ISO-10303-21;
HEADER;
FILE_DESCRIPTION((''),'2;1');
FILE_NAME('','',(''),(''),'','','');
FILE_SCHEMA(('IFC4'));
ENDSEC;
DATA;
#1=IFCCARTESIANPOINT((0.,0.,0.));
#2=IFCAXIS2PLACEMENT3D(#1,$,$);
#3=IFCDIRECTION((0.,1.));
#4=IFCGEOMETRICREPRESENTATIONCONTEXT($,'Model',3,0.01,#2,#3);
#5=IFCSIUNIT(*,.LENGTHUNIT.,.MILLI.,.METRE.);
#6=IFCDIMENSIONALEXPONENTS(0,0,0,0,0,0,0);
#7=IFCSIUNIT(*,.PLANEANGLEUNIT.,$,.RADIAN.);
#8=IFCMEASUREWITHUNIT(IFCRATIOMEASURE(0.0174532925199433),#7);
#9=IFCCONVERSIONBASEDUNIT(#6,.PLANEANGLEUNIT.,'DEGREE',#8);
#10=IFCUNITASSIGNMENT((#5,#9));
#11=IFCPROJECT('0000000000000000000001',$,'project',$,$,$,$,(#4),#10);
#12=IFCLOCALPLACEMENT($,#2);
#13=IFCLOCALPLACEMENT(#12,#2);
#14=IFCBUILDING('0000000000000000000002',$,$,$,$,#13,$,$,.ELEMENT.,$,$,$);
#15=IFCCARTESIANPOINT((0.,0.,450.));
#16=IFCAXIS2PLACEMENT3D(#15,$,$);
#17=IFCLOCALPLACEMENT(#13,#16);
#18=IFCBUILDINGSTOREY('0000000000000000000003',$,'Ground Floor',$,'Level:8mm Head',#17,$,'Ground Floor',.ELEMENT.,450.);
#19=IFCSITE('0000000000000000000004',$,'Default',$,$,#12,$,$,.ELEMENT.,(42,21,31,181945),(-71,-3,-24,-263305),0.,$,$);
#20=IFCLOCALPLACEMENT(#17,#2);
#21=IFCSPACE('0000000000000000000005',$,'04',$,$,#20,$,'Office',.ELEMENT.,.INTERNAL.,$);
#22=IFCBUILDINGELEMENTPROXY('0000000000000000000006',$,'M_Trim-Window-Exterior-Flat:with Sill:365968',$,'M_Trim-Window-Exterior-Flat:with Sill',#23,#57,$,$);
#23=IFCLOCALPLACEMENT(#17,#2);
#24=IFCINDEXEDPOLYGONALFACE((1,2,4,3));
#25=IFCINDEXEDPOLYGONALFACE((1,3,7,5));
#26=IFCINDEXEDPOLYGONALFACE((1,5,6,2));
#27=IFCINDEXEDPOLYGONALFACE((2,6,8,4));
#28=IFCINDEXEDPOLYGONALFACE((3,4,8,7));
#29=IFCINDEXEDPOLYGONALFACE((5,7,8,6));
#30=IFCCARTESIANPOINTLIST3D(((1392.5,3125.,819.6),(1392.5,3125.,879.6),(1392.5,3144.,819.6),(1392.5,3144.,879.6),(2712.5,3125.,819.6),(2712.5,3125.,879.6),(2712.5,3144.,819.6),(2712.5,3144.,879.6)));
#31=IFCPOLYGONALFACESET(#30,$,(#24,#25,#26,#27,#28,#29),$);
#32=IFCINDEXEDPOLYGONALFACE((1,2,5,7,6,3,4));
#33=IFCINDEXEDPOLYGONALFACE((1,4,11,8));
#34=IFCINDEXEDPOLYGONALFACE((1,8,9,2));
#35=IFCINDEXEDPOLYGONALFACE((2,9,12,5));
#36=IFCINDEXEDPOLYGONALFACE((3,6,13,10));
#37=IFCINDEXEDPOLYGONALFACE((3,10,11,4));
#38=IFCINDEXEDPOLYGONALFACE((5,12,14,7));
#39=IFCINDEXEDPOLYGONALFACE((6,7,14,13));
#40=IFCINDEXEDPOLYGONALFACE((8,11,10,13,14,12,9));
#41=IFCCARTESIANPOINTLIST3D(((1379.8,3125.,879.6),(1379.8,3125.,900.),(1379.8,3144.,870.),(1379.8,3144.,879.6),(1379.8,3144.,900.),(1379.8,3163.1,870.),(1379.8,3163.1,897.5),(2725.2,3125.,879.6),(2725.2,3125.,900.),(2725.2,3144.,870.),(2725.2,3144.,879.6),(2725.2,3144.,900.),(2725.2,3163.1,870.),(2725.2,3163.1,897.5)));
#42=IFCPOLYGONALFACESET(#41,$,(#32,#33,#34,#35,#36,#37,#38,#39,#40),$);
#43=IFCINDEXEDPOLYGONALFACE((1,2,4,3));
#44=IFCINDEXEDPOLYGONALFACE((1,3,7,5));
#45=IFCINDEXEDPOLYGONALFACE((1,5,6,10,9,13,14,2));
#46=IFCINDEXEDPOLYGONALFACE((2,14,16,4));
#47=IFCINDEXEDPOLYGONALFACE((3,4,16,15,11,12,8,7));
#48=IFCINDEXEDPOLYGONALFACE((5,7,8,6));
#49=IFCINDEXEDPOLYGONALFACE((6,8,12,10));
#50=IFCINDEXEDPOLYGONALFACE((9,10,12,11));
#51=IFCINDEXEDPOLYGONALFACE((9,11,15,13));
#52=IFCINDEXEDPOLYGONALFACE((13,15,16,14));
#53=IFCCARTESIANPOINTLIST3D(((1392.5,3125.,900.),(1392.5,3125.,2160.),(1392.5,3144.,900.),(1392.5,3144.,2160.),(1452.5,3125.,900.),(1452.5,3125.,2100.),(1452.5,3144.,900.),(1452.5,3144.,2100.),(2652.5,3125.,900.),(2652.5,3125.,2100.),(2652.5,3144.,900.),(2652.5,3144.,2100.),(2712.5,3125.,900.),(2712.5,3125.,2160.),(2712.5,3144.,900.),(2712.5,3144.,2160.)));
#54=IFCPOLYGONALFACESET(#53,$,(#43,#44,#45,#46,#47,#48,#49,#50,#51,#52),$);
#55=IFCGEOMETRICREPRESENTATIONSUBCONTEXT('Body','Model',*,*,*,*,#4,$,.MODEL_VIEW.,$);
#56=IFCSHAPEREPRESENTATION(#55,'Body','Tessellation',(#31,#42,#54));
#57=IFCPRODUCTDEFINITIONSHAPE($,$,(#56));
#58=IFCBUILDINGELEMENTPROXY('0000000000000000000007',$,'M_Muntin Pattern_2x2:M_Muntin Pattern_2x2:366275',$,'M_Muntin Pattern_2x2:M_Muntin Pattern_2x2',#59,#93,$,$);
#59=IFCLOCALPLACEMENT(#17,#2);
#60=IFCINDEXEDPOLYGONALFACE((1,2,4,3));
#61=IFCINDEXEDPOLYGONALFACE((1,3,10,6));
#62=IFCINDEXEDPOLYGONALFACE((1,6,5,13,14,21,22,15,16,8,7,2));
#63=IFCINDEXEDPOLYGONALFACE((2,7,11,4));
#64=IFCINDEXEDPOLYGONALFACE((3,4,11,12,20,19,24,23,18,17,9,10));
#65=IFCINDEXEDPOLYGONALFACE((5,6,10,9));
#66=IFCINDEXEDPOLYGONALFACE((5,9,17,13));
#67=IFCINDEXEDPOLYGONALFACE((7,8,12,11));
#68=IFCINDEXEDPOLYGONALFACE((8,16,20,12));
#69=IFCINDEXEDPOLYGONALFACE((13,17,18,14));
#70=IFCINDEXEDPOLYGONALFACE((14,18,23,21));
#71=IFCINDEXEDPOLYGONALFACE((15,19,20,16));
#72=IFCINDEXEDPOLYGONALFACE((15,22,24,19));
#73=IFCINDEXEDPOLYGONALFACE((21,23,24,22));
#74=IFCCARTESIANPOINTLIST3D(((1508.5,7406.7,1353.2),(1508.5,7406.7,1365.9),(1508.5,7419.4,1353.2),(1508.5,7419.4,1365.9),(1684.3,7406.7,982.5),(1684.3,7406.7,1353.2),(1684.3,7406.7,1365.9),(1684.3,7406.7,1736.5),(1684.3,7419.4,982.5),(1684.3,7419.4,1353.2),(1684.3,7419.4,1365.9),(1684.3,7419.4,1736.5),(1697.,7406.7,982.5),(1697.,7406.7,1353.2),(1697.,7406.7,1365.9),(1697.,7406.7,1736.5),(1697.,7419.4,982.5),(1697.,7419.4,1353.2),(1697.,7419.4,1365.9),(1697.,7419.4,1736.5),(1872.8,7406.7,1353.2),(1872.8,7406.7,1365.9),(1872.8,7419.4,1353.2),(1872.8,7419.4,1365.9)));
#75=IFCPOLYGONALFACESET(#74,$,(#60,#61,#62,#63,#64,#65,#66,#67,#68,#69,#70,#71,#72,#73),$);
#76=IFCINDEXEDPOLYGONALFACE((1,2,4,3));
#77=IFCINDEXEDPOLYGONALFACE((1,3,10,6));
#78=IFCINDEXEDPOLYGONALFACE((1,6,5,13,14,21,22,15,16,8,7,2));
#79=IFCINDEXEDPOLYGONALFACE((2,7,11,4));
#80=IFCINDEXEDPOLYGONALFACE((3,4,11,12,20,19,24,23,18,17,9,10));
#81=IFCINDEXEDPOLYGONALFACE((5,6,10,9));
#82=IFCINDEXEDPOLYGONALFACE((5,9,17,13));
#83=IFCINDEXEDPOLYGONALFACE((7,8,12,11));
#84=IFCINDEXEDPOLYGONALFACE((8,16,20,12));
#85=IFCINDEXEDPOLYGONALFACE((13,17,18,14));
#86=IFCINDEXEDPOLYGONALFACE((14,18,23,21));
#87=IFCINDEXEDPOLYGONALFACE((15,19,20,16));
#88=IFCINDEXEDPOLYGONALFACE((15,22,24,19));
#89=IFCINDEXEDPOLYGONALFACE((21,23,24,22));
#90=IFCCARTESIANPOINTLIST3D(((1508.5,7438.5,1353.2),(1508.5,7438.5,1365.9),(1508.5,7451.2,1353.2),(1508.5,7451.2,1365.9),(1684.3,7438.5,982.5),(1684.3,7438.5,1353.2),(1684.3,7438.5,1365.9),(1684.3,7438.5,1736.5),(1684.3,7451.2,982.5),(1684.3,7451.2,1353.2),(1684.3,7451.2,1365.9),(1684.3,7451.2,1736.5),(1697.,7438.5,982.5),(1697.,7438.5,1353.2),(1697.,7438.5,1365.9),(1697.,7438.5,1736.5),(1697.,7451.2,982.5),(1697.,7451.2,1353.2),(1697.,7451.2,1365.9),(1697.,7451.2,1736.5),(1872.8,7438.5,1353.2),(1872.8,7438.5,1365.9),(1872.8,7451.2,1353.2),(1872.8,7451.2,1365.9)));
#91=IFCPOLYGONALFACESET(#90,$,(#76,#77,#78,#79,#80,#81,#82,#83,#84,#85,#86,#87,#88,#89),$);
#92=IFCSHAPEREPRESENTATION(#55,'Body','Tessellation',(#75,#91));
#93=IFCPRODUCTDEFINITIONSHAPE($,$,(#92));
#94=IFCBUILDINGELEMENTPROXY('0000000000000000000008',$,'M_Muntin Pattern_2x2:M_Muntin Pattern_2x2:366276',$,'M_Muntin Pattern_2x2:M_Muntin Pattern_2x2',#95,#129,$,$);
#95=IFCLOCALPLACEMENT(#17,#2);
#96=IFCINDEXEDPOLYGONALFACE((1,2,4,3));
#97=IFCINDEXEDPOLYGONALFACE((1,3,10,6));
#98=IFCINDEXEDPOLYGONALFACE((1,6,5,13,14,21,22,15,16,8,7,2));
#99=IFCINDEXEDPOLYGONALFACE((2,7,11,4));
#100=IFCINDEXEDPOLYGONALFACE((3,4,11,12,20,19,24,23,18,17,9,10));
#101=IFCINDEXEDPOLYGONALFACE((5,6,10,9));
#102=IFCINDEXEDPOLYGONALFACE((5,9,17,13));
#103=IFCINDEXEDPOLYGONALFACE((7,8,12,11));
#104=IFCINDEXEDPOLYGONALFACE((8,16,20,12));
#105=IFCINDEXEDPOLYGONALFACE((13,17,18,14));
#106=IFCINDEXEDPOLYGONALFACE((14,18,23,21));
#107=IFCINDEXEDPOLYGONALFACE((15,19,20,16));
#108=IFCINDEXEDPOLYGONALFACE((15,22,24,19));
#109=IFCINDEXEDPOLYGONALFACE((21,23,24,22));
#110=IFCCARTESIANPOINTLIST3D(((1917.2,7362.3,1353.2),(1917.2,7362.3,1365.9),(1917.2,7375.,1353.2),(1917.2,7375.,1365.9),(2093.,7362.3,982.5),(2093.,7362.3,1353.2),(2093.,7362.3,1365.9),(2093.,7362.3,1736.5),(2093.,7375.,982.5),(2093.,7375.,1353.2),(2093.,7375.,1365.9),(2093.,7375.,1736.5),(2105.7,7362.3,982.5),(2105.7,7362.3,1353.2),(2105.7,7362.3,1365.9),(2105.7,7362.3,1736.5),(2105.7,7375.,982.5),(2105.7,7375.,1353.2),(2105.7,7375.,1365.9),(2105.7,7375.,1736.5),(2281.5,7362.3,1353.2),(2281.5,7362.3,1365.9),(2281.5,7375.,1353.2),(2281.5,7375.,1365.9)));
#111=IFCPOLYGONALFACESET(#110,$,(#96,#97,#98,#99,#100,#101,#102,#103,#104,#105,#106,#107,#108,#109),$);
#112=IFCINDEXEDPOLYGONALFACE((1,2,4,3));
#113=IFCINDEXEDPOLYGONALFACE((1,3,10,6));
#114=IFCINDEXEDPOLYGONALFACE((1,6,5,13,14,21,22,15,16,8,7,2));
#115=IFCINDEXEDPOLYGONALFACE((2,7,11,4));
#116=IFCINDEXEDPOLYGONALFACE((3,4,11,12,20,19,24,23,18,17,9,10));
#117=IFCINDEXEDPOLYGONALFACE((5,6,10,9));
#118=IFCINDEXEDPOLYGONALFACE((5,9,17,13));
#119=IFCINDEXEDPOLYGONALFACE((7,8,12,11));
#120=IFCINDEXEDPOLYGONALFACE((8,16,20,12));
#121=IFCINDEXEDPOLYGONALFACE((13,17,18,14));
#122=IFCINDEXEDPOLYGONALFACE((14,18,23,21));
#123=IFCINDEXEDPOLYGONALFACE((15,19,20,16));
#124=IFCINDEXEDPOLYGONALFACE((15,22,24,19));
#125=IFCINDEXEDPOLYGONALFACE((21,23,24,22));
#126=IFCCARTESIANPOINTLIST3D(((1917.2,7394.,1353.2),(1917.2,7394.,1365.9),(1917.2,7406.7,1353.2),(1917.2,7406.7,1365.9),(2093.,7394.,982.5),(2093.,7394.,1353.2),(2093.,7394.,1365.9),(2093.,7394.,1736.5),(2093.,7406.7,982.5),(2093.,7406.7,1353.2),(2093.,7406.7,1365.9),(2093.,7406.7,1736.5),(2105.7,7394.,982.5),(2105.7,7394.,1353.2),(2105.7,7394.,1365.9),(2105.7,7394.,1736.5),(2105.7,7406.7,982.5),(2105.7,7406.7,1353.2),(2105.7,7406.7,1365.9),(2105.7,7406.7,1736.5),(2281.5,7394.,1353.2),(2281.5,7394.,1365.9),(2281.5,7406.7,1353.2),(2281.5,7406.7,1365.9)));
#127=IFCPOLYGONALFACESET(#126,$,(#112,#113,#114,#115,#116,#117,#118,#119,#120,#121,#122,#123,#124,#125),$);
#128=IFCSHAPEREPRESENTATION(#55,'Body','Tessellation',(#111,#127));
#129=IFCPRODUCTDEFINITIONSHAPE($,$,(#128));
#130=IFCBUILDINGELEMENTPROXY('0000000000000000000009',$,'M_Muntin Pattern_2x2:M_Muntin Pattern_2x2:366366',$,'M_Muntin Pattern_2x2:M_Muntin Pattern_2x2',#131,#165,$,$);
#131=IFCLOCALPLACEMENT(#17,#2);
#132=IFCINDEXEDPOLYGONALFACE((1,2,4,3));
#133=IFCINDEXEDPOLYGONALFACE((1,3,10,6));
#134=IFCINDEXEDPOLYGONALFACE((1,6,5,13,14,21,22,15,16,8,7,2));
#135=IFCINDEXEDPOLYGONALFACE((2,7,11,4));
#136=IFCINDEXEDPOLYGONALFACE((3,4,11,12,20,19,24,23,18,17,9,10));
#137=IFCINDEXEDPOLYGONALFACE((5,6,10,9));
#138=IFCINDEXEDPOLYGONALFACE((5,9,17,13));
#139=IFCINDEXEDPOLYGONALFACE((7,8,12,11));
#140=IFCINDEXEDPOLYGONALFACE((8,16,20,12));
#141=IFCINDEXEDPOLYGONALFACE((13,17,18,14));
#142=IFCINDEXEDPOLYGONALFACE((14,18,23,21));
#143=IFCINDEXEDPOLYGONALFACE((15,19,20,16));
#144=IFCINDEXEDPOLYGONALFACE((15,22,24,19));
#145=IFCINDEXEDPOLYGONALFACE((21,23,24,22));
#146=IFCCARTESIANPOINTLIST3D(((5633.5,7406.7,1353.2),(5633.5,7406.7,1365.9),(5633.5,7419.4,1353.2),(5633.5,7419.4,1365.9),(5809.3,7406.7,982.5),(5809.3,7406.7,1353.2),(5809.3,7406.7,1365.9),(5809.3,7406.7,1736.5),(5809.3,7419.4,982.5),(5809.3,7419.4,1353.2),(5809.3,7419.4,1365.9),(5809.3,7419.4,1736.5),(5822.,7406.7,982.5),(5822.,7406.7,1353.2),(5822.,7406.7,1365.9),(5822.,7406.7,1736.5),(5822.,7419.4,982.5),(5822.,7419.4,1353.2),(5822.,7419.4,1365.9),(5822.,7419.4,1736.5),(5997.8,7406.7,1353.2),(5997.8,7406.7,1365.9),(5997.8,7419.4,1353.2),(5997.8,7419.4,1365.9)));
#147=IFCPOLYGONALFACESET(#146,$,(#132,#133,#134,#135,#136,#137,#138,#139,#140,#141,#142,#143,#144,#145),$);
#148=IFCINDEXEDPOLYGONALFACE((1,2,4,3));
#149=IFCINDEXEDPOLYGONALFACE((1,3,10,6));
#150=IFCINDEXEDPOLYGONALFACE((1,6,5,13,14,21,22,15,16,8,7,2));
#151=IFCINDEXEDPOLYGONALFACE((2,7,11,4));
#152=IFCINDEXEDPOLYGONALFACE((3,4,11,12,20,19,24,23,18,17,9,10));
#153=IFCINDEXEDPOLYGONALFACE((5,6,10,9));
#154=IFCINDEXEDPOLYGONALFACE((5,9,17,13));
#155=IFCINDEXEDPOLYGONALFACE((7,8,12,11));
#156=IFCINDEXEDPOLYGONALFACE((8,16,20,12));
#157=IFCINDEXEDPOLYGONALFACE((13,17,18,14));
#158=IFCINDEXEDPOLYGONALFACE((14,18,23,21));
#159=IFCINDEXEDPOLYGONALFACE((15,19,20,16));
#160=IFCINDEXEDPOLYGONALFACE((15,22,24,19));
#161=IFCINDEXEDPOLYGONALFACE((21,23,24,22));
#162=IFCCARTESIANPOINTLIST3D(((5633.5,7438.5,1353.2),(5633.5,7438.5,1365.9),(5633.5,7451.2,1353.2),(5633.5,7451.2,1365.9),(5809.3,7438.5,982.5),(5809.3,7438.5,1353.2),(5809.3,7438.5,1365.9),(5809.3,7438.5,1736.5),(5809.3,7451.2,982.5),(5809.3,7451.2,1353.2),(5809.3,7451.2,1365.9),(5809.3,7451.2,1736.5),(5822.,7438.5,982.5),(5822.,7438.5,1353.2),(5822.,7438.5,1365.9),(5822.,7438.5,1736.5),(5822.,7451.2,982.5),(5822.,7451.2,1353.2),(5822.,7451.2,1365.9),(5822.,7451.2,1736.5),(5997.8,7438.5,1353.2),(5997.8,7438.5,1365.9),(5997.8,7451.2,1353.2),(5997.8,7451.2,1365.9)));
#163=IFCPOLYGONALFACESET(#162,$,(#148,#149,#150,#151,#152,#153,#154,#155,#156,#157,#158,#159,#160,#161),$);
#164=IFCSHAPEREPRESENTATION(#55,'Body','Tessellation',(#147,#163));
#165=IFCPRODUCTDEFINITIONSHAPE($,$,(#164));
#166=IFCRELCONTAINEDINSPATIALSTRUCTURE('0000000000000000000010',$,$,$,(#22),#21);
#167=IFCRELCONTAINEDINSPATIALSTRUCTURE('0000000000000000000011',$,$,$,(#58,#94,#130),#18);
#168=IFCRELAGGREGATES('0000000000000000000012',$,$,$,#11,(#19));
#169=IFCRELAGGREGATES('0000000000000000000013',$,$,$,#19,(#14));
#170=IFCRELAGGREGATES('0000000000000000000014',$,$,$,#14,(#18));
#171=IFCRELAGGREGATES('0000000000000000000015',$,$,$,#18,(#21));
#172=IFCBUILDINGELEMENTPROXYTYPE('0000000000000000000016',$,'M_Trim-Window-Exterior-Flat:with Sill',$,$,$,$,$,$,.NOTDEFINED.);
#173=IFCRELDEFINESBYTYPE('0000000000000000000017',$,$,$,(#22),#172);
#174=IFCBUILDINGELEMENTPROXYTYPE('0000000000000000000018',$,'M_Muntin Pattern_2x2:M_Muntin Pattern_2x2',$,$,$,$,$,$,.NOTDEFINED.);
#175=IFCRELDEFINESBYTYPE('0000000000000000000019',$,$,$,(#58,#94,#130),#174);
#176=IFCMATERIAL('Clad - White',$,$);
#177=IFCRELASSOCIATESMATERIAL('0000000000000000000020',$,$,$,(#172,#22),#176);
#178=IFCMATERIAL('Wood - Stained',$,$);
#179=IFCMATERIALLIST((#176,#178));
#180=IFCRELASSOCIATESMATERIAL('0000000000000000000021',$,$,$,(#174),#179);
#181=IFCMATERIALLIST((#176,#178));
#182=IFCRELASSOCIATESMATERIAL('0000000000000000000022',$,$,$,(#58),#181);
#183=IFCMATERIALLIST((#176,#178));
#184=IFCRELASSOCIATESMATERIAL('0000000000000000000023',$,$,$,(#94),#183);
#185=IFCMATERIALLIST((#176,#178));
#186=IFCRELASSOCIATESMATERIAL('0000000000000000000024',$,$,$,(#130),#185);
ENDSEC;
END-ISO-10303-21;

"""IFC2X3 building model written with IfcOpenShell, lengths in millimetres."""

from ifc_helpers import new_model, entity, si_unit, converted_unit, direction, frame, frame_2d, origin, place, context, subcontext, project, spatial, polyline, rectangle, outline, extrude, source, transform, mapped, material, material_list, type_object, type_shapes, element, save


model = new_model("IFC2X3")

# Units and contexts
model_context = context("Model", 3, precision=0.01, world=origin(), true_north=direction((0.0, 1.0)))
body_context = subcontext(model_context, "Body", "Model", "MODEL_VIEW")
ifc_project = project(units=[si_unit("LENGTHUNIT", "METRE", prefix="MILLI"), converted_unit("PLANEANGLEUNIT", "DEGREE", entity("IfcRatioMeasure", 0.0174532925199433), si_unit("PLANEANGLEUNIT", "RADIAN"), dimensions=[0, 0, 0, 0, 0, 0, 0])], contexts=[model_context])

# Site, building, storey
site_placement = place(None, origin())
site = spatial("IfcSite", under=ifc_project, at=site_placement, Name="Default", CompositionType="ELEMENT", RefLatitude=(42, 21, 31, 181945), RefLongitude=(-71, -3, -24, -263305), RefElevation=0.0)
building_placement = place(site_placement, origin())
building = spatial("IfcBuilding", under=site, at=building_placement, CompositionType="ELEMENT")
storey_placement = place(building_placement, frame((0.0, 0.0, 450.0)))
storey = spatial("IfcBuildingStorey", under=building, at=storey_placement, Name="Ground Floor", ObjectType="Level:8mm Head", LongName="Ground Floor", CompositionType="ELEMENT", Elevation=450.0)

# Shared definitions
space_1_placement = place(storey_placement, origin())
space_1 = spatial("IfcSpace", under=storey, at=space_1_placement, Name="04", LongName="Office", CompositionType="ELEMENT", InteriorOrExteriorSpace="INTERNAL")

# Building element proxies
ifc_material_1 = material(Name="Clad - White")
building_element_proxy_type_1 = type_object("IfcBuildingElementProxyType", Name="M_Trim-Window-Exterior-Flat:with Sill", PredefinedType="NOTDEFINED", material=ifc_material_1)
shared_shape_1 = source(origin(), body_context, "Body", "SweptSolid", [
    extrude(rectangle(XDim=1320.0, YDim=60.0, at=frame_2d((0.0, 0.0), x_axis=(1.0, 0.0))), frame((0.0, -1250.4, 0.0), z_axis=(0.0, 0.0, 1.0), x_axis=(-1.0, 0.0, 0.0)), (0.0, 0.0, 1.0), 19.1),
    extrude(outline(polyline([(-19.0, -15.2), (0.0, -15.2), (0.0, -5.7), (19.0, -5.7), (19.0, 14.8), (0.0, 14.8), (-19.0, 12.3), (-19.0, -15.2)])), frame((-672.7, -1214.8, 19.0), z_axis=(1.0, 0.0, 0.0), x_axis=(0.0, 0.0, -1.0)), (0.0, 0.0, 1.0), 1345.4),
    extrude(outline(polyline([(-645.0, -660.0), (615.0, -660.0), (615.0, -600.0), (-585.0, -600.0), (-585.0, 600.0), (615.0, 600.0), (615.0, 660.0), (-645.0, 660.0), (-645.0, -660.0)])), frame((0.0, -585.0, 0.0), z_axis=(0.0, 0.0, 1.0), x_axis=(0.0, -1.0, 0.0)), (0.0, 0.0, 1.0), 19.1),
])
type_shapes(building_element_proxy_type_1, [shared_shape_1])
proxy_1_placement = place(space_1_placement, frame((2052.5, 3125.0, 2100.0), z_axis=(0.0, 1.0, 0.0), x_axis=(-1.0, 0.0, 0.0)))
element("IfcBuildingElementProxy", 1, at=proxy_1_placement, inside=space_1, type_object=building_element_proxy_type_1, material=ifc_material_1, Name="M_Trim-Window-Exterior-Flat:with Sill:365968", ObjectType="M_Trim-Window-Exterior-Flat:with Sill", context=body_context, shape_type="MappedRepresentation", body=[
    mapped(shared_shape_1, transform((0.0, 0.0, 0.0), scale=1.0)),
])
ifc_material_2 = material(Name="Wood - Stained")
ifc_material_list_1 = material_list([ifc_material_1, ifc_material_2])
ifc_material_list_2 = material_list([ifc_material_1, ifc_material_2])
building_element_proxy_type_2 = type_object("IfcBuildingElementProxyType", Name="M_Muntin Pattern_2x2:M_Muntin Pattern_2x2", PredefinedType="NOTDEFINED", material=ifc_material_list_2)
shared_shape_2 = source(origin(), body_context, "Body", "SweptSolid", [
    extrude(outline(polyline([(6.4, -6.4), (377.0, -6.4), (377.0, 6.3), (6.4, 6.3), (6.4, 182.1), (-6.3, 182.1), (-6.3, 6.3), (-377.0, 6.3), (-377.0, -6.4), (-6.3, -6.4), (-6.3, -182.1), (6.4, -182.1), (6.4, -6.4)])), frame((0.0, 9.5, 377.0), z_axis=(0.0, 1.0, 0.0), x_axis=(0.0, 0.0, 1.0)), (0.0, 0.0, 1.0), 12.7),
    extrude(outline(polyline([(6.4, -6.4), (377.0, -6.4), (377.0, 6.3), (6.4, 6.3), (6.4, 182.1), (-6.3, 182.1), (-6.3, 6.3), (-377.0, 6.3), (-377.0, -6.4), (-6.3, -6.4), (-6.3, -182.1), (6.4, -182.1), (6.4, -6.4)])), frame((0.0, -22.2, 377.0), z_axis=(0.0, 1.0, 0.0), x_axis=(0.0, 0.0, 1.0)), (0.0, 0.0, 1.0), 12.7),
])
type_shapes(building_element_proxy_type_2, [shared_shape_2])
proxy_2_placement = place(storey_placement, frame((1690.6, 7429.0, 982.5), z_axis=(0.0, 0.0, 1.0), x_axis=(-1.0, 0.0, 0.0)))
element("IfcBuildingElementProxy", 2, at=proxy_2_placement, inside=storey, type_object=building_element_proxy_type_2, material=ifc_material_list_1, Name="M_Muntin Pattern_2x2:M_Muntin Pattern_2x2:366275", ObjectType="M_Muntin Pattern_2x2:M_Muntin Pattern_2x2", context=body_context, shape_type="MappedRepresentation", body=[
    mapped(shared_shape_2, transform((0.0, 0.0, 0.0), scale=1.0)),
])
ifc_material_list_3 = material_list([ifc_material_1, ifc_material_2])
proxy_3_placement = place(storey_placement, frame((2099.4, 7384.5, 982.5), z_axis=(0.0, 0.0, 1.0), x_axis=(-1.0, 0.0, 0.0)))
element("IfcBuildingElementProxy", 3, at=proxy_3_placement, inside=storey, type_object=building_element_proxy_type_2, material=ifc_material_list_3, Name="M_Muntin Pattern_2x2:M_Muntin Pattern_2x2:366276", ObjectType="M_Muntin Pattern_2x2:M_Muntin Pattern_2x2", context=body_context, shape_type="MappedRepresentation", body=[
    mapped(shared_shape_2, transform((0.0, 0.0, 0.0), scale=1.0)),
])
ifc_material_list_4 = material_list([ifc_material_1, ifc_material_2])
proxy_4_placement = place(storey_placement, frame((5815.6, 7429.0, 982.5), z_axis=(0.0, 0.0, 1.0), x_axis=(-1.0, 0.0, 0.0)))
element("IfcBuildingElementProxy", 4, at=proxy_4_placement, inside=storey, type_object=building_element_proxy_type_2, material=ifc_material_list_4, Name="M_Muntin Pattern_2x2:M_Muntin Pattern_2x2:366366", ObjectType="M_Muntin Pattern_2x2:M_Muntin Pattern_2x2", context=body_context, shape_type="MappedRepresentation", body=[
    mapped(shared_shape_2, transform((0.0, 0.0, 0.0), scale=1.0)),
])

save(model, "model.ifc")
